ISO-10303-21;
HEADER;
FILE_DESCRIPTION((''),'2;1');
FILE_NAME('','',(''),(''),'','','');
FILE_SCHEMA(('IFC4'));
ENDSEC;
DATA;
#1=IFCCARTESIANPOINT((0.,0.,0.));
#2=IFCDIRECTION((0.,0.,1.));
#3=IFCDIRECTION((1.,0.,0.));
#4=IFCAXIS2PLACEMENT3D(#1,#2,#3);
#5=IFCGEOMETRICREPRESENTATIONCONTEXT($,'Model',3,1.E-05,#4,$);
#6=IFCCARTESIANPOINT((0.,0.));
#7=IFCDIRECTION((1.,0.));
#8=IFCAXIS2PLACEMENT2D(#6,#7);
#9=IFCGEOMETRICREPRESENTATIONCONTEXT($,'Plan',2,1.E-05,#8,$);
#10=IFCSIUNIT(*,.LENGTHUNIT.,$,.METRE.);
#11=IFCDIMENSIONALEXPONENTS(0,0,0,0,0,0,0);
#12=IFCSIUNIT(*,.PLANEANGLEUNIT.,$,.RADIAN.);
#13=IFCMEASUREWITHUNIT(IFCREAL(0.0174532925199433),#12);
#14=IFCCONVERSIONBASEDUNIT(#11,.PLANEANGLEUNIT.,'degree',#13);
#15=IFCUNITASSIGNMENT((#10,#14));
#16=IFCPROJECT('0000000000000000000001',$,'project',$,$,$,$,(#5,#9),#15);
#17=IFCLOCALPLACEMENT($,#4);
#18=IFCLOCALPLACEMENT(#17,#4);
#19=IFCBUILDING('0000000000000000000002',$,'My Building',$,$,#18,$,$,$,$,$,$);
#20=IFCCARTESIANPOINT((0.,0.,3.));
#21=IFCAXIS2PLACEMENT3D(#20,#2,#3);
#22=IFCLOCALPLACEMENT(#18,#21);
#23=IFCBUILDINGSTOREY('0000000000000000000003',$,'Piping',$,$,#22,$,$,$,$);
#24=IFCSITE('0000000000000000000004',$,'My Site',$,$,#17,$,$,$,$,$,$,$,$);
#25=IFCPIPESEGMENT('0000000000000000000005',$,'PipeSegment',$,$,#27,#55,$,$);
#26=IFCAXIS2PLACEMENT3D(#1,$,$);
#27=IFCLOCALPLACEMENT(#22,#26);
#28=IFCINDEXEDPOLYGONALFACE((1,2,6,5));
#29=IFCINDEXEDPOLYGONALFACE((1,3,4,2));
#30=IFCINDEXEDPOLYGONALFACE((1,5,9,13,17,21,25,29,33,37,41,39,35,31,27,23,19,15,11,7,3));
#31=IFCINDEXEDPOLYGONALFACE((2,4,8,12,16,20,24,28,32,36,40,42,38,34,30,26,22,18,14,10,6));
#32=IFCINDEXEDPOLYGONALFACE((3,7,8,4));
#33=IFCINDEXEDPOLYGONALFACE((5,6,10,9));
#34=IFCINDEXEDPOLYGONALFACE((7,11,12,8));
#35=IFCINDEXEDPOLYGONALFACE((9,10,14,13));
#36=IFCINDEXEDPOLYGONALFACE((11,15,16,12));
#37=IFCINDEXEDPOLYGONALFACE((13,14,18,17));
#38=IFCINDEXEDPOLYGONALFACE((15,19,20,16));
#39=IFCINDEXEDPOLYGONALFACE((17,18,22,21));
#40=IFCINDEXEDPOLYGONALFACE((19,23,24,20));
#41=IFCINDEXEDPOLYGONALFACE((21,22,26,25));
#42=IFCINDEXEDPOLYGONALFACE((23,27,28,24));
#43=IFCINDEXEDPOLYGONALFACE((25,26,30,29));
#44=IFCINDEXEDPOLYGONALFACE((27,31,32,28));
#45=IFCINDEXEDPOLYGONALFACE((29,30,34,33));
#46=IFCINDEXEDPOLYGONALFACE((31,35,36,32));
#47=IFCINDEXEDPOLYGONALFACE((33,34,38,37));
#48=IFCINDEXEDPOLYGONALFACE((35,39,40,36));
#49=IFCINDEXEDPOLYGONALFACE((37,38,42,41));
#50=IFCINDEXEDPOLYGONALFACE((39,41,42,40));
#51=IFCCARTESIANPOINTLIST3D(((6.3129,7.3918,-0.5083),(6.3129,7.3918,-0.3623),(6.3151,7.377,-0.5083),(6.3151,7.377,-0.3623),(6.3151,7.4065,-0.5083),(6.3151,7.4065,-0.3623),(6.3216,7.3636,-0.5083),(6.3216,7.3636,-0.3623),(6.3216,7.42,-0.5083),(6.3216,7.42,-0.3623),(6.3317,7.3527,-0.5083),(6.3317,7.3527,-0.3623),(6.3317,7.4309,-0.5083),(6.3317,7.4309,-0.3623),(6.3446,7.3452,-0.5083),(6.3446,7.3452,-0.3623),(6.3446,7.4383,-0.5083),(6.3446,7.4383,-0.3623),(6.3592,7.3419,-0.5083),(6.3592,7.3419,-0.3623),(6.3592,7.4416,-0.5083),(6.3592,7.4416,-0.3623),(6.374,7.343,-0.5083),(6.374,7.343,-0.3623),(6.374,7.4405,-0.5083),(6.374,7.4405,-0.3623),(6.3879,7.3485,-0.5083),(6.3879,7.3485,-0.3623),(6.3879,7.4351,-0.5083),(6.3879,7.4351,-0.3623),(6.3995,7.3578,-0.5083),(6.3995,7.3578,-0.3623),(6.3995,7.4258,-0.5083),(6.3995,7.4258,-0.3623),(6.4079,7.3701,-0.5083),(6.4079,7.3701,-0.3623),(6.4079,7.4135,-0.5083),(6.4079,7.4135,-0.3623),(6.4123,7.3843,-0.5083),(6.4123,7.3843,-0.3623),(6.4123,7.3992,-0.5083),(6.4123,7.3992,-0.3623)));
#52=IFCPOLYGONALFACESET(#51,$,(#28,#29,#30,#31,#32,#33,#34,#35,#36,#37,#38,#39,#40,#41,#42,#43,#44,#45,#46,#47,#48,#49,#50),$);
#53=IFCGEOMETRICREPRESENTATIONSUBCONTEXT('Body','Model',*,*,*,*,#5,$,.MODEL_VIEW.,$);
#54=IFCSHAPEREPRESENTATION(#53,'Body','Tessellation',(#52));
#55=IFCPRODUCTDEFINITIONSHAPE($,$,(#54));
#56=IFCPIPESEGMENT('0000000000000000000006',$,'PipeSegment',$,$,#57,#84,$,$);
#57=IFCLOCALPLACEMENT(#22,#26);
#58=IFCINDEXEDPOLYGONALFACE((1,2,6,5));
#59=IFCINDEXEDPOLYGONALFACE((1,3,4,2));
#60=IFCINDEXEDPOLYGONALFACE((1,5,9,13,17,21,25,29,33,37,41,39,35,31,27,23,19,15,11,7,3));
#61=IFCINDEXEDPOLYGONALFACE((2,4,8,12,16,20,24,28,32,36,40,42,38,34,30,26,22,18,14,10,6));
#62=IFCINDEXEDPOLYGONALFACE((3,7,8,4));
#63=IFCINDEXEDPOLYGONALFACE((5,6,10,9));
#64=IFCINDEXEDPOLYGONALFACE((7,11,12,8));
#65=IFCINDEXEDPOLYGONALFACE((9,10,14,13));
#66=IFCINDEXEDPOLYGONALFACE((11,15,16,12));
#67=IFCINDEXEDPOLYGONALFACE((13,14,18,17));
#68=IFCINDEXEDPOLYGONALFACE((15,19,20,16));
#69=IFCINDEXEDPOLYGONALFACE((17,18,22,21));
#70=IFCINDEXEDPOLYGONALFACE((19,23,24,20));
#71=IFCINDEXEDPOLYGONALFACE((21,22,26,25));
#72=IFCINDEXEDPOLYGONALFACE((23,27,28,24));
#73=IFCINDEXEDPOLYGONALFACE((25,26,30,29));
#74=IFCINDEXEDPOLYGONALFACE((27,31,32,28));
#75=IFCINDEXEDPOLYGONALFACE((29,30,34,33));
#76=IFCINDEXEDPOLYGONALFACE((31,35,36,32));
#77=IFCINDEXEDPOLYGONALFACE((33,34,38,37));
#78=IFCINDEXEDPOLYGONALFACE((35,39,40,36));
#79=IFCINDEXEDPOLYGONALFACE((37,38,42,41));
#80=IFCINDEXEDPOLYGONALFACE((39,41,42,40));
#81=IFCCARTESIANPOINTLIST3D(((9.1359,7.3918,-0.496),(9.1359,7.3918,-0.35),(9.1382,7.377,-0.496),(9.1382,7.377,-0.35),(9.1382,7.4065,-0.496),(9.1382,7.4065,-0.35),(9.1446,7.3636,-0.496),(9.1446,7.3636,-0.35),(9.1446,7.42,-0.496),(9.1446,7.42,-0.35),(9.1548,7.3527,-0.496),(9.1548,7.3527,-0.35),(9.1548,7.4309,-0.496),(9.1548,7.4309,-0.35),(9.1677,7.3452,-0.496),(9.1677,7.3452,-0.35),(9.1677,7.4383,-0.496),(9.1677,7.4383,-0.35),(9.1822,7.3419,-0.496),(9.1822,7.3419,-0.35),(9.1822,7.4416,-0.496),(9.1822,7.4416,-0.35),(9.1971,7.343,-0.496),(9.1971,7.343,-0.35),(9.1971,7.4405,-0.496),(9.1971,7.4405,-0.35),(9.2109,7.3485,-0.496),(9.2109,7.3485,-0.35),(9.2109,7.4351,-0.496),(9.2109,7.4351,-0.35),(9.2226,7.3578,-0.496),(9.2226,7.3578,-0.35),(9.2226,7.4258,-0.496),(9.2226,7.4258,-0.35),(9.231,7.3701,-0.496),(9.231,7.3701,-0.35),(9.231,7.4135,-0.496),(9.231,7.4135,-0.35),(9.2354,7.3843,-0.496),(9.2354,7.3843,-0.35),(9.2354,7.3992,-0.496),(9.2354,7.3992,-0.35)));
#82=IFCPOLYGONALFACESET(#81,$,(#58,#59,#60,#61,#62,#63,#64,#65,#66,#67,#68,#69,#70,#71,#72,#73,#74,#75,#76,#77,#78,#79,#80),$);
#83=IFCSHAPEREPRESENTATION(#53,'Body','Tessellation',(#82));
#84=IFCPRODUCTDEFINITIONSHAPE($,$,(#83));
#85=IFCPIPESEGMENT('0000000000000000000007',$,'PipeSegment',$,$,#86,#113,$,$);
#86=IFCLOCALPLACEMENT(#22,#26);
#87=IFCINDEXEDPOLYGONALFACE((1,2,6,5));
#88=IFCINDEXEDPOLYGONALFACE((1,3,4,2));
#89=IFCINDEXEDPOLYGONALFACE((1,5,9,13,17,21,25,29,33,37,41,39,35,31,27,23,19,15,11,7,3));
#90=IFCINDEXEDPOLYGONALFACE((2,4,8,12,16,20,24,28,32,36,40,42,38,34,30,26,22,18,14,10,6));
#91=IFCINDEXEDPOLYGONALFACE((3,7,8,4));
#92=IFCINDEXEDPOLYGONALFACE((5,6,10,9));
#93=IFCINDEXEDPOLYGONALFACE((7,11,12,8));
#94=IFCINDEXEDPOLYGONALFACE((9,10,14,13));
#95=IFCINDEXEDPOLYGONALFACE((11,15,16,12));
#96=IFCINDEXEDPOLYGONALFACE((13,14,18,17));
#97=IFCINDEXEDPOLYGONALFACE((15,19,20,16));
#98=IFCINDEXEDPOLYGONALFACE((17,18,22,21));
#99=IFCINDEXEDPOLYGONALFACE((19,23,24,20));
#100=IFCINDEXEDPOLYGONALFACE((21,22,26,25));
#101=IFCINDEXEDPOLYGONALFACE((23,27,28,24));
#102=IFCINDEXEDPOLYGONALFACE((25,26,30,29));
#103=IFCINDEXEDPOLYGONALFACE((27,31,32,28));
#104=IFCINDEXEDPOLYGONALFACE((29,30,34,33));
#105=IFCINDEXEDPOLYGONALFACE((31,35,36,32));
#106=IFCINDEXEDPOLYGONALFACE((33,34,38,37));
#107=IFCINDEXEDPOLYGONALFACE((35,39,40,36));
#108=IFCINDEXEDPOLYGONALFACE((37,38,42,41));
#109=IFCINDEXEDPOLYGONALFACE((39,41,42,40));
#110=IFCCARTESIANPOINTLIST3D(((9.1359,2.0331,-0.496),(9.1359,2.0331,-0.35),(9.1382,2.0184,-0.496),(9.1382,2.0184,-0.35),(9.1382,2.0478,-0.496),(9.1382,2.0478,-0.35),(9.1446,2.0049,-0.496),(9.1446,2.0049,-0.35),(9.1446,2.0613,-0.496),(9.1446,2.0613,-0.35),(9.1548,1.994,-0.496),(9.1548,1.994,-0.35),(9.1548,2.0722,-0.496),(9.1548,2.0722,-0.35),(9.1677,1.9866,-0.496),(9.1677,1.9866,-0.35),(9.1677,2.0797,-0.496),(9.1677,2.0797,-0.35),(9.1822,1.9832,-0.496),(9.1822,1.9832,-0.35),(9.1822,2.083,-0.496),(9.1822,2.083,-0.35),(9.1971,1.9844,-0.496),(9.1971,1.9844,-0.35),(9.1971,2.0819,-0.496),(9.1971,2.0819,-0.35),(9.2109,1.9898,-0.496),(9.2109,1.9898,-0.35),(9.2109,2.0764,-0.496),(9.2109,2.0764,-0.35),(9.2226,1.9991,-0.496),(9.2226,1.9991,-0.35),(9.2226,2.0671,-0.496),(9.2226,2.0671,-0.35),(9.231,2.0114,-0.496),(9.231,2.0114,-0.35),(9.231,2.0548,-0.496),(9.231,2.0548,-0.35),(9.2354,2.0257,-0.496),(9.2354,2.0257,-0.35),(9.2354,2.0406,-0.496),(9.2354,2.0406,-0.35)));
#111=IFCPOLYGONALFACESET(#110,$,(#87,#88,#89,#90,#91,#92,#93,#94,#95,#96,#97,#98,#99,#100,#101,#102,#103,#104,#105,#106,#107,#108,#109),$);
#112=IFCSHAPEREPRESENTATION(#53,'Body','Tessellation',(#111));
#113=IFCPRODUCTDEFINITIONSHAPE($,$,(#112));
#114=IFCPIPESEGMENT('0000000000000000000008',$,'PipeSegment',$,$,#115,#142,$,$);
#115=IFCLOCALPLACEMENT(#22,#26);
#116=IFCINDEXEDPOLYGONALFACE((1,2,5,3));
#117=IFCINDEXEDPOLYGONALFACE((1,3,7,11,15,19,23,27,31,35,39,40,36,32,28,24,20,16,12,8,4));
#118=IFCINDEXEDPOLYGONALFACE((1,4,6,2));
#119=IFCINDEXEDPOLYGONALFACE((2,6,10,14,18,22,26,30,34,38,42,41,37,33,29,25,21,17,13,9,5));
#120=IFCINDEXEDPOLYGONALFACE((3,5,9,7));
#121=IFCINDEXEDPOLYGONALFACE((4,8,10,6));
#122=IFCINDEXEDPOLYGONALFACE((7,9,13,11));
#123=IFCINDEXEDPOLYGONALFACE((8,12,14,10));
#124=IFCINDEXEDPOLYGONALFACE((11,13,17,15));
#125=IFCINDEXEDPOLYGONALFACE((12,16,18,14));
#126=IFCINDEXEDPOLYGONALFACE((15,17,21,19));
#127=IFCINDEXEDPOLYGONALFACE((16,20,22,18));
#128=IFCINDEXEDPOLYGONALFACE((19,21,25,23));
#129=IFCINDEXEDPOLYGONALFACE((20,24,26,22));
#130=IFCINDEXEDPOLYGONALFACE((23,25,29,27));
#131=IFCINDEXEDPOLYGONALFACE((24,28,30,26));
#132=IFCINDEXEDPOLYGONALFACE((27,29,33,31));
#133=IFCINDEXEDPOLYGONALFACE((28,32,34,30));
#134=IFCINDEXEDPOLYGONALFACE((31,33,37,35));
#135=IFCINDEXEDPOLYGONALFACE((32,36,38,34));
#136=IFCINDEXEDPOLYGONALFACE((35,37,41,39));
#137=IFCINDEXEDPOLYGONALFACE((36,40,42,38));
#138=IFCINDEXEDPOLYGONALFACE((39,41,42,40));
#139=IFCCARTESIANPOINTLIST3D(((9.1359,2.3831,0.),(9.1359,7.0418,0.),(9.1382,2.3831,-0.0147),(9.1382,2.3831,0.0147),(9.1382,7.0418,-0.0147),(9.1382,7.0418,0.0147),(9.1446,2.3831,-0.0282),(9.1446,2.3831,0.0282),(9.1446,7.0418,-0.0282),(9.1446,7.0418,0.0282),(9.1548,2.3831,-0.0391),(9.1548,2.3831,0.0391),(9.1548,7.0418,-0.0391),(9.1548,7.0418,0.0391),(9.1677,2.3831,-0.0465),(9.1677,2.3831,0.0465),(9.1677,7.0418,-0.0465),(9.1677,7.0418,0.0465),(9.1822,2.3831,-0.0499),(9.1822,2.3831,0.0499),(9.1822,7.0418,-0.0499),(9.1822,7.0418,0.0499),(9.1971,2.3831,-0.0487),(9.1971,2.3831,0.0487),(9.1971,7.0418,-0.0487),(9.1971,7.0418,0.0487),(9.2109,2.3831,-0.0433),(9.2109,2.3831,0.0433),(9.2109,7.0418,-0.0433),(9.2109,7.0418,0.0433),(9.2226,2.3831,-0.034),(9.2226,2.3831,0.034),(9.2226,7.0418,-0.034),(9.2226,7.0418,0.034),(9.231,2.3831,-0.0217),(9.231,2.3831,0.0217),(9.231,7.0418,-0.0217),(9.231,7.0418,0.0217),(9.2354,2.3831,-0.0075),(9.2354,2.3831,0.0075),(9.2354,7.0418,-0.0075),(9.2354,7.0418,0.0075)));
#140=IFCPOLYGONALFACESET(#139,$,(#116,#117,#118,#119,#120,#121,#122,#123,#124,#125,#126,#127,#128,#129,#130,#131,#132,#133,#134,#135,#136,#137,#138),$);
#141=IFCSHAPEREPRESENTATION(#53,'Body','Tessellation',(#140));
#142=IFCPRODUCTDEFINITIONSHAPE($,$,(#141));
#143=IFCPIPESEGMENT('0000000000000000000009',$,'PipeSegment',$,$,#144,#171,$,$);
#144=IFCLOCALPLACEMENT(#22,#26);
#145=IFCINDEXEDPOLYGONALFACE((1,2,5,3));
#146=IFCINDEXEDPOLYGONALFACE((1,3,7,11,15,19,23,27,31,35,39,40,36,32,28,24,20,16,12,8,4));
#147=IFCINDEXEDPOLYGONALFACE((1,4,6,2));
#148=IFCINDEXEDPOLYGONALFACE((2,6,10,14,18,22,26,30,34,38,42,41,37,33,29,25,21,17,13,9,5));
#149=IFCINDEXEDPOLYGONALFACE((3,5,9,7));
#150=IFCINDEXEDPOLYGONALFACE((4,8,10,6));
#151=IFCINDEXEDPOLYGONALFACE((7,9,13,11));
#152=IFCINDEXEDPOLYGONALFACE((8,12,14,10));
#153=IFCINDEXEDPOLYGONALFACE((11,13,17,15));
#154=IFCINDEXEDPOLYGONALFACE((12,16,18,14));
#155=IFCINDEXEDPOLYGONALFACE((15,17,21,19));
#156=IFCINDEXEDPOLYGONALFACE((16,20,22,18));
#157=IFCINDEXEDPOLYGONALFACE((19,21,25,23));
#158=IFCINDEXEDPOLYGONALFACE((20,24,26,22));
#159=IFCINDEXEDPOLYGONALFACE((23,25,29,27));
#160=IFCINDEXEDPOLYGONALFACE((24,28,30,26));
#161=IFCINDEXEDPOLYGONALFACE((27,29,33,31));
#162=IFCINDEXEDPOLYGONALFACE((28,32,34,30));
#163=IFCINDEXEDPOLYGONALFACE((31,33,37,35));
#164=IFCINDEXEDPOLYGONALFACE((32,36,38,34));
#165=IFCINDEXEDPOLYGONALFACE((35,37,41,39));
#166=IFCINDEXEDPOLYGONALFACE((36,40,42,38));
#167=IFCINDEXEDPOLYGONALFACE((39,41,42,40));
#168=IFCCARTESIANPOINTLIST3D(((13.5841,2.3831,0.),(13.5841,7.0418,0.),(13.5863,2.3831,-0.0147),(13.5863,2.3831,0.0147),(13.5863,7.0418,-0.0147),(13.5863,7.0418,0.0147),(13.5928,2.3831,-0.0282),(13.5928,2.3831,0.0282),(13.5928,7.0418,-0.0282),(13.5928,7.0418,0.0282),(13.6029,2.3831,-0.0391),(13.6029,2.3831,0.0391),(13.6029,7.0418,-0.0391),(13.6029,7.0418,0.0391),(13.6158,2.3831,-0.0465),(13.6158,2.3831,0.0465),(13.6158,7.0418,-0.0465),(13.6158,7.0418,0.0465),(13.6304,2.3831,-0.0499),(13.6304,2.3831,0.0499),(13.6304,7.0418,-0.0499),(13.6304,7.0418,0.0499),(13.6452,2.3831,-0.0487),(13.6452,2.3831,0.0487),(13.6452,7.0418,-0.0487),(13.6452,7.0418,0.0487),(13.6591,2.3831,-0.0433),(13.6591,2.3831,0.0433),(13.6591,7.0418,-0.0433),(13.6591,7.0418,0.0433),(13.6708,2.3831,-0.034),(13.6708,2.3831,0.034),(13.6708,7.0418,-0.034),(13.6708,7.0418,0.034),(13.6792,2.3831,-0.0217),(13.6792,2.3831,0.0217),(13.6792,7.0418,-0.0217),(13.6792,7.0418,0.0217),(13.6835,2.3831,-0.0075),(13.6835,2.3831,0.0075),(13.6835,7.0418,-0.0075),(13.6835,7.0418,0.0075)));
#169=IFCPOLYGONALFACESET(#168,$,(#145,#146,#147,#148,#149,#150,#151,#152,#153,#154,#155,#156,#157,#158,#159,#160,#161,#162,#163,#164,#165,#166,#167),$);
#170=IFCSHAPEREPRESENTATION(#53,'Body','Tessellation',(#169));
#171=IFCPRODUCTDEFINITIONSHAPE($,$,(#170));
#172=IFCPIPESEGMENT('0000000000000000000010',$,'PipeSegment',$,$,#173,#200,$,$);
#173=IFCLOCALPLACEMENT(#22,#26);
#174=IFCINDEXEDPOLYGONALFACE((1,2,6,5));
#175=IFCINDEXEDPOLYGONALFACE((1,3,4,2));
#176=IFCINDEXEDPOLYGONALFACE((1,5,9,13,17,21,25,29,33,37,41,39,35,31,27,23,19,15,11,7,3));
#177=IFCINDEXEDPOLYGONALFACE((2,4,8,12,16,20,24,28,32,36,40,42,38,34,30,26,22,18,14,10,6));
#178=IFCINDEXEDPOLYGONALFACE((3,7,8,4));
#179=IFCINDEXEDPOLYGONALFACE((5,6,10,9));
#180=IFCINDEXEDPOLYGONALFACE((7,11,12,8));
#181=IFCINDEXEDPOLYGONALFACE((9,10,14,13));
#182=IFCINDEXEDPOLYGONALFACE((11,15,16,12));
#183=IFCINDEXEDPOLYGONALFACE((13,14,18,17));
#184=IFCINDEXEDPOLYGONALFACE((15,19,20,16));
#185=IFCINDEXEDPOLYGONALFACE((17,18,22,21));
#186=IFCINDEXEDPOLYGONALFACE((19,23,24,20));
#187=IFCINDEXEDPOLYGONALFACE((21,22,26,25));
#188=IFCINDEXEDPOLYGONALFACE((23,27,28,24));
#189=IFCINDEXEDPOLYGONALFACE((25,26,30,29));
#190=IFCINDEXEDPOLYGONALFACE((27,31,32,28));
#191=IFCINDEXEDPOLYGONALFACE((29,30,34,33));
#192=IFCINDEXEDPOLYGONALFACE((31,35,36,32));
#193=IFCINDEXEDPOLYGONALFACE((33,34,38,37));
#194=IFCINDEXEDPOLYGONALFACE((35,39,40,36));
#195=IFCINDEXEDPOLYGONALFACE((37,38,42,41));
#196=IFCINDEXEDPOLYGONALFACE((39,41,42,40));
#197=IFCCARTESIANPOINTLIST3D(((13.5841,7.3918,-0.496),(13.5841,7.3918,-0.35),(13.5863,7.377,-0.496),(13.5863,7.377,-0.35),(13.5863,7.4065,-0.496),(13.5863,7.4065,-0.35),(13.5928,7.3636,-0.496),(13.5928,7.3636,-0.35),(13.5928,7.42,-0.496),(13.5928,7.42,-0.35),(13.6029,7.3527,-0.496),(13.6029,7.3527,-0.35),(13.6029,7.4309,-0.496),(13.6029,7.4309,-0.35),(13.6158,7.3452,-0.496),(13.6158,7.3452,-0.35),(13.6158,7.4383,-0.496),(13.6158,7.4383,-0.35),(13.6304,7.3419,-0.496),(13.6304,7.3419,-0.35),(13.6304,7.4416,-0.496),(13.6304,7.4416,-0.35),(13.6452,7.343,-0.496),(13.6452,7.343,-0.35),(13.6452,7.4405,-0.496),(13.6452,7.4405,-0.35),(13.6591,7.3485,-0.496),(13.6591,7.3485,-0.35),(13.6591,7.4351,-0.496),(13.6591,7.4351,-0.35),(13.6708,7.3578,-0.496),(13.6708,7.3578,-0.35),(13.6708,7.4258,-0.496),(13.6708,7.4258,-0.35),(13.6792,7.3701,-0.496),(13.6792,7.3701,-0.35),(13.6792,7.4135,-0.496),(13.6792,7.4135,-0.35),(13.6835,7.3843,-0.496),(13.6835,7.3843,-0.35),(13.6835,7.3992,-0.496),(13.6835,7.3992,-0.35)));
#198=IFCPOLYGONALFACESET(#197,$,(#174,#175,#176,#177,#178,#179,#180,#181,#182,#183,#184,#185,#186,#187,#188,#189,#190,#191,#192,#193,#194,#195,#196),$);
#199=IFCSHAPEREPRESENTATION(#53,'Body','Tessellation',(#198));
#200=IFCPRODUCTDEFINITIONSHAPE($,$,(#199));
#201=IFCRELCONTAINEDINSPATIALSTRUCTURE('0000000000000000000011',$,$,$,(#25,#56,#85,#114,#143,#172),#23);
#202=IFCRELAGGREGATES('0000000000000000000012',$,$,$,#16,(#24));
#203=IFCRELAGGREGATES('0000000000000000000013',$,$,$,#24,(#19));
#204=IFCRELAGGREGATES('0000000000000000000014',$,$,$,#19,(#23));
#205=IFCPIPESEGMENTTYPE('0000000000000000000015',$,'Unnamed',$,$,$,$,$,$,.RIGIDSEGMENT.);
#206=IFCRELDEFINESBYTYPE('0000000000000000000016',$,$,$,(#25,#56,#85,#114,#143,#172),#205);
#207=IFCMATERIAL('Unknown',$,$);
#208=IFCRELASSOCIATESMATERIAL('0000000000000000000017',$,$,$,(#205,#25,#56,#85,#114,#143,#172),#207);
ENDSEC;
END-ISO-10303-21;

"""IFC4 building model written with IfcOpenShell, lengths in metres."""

from ifc_helpers import new_model, entity, si_unit, converted_unit, frame, origin_with_axes, origin_2d_with_axis, place, context, subcontext, project, spatial, circle, extrude, material, material_profile, profile_set, profile_usage, type_object, element, save


model = new_model("IFC4")

# Units and contexts
model_context = context("Model", 3, precision=1e-05, world=origin_with_axes())
plan_context = context("Plan", 2, precision=1e-05, world=origin_2d_with_axis())
body_context = subcontext(model_context, "Body", "Model", "MODEL_VIEW")
ifc_project = project(units=[si_unit("LENGTHUNIT", "METRE"), converted_unit("PLANEANGLEUNIT", "degree", entity("IfcReal", 0.0174532925199433), si_unit("PLANEANGLEUNIT", "RADIAN"), dimensions=[0, 0, 0, 0, 0, 0, 0])], contexts=[model_context, plan_context])

# Site, building, storey
site_placement = place(None, origin_with_axes())
site = spatial("IfcSite", under=ifc_project, at=site_placement, Name="My Site")
building_placement = place(site_placement, origin_with_axes())
building = spatial("IfcBuilding", under=site, at=building_placement, Name="My Building")
storey_placement = place(building_placement, frame((0.0, 0.0, 3.0), z_axis=(0.0, 0.0, 1.0), x_axis=(1.0, 0.0, 0.0)))
storey = spatial("IfcBuildingStorey", under=building, at=storey_placement, Name="Piping")

# Pipe segments
ifc_material = material(Name="Unknown")
ifc_material_profile = material_profile(ifc_material, circle(Radius=0.05))
ifc_profile_set = profile_set([ifc_material_profile])
pipe_segment_type = type_object("IfcPipeSegmentType", Name="Unnamed", PredefinedType="RIGIDSEGMENT", material=ifc_profile_set)
ifc_profile_usage_1 = profile_usage(ifc_profile_set, cardinal=5)
pipe_segment_1_placement = place(storey_placement, frame((6.3629, 7.3918, -0.3623), z_axis=(0.0, 0.0, -1.0), x_axis=(-1.0, 0.0, 0.0)))
element("IfcPipeSegment", 1, at=pipe_segment_1_placement, inside=storey, type_object=pipe_segment_type, material=ifc_profile_usage_1, Name="PipeSegment", context=body_context, shape_type="SweptSolid", body=[
    extrude(circle(Radius=0.05), origin_with_axes(), (0.0, 0.0, 1.0), 0.1459),
])
ifc_profile_usage_2 = profile_usage(ifc_profile_set, cardinal=5)
pipe_segment_2_placement = place(storey_placement, frame((9.1859, 7.3918, -0.35), z_axis=(0.0, 0.0, -1.0), x_axis=(-1.0, 0.0, 0.0)))
element("IfcPipeSegment", 2, at=pipe_segment_2_placement, inside=storey, type_object=pipe_segment_type, material=ifc_profile_usage_2, Name="PipeSegment", context=body_context, shape_type="SweptSolid", body=[
    extrude(circle(Radius=0.05), origin_with_axes(), (0.0, 0.0, 1.0), 0.1459),
])
ifc_profile_usage_3 = profile_usage(ifc_profile_set, cardinal=5)
pipe_segment_3_placement = place(storey_placement, frame((9.1859, 2.0331, -0.35), z_axis=(0.0, 0.0, -1.0), x_axis=(-1.0, 0.0, 0.0)))
element("IfcPipeSegment", 3, at=pipe_segment_3_placement, inside=storey, type_object=pipe_segment_type, material=ifc_profile_usage_3, Name="PipeSegment", context=body_context, shape_type="SweptSolid", body=[
    extrude(circle(Radius=0.05), origin_with_axes(), (0.0, 0.0, 1.0), 0.1459),
])
ifc_profile_usage_4 = profile_usage(ifc_profile_set, cardinal=5)
pipe_segment_4_placement = place(storey_placement, frame((9.1859, 2.3831, 0.0), z_axis=(0.0, 1.0, 0.0), x_axis=(-1.0, 0.0, 0.0)))
element("IfcPipeSegment", 4, at=pipe_segment_4_placement, inside=storey, type_object=pipe_segment_type, material=ifc_profile_usage_4, Name="PipeSegment", context=body_context, shape_type="SweptSolid", body=[
    extrude(circle(Radius=0.05), origin_with_axes(), (0.0, 0.0, 1.0), 4.6587),
])
ifc_profile_usage_5 = profile_usage(ifc_profile_set, cardinal=5)
pipe_segment_5_placement = place(storey_placement, frame((13.6341, 2.3831, 0.0), z_axis=(0.0, 1.0, 0.0), x_axis=(-1.0, 0.0, 0.0)))
element("IfcPipeSegment", 5, at=pipe_segment_5_placement, inside=storey, type_object=pipe_segment_type, material=ifc_profile_usage_5, Name="PipeSegment", context=body_context, shape_type="SweptSolid", body=[
    extrude(circle(Radius=0.05), origin_with_axes(), (0.0, 0.0, 1.0), 4.6587),
])
ifc_profile_usage_6 = profile_usage(ifc_profile_set, cardinal=5)
pipe_segment_6_placement = place(storey_placement, frame((13.6341, 7.3918, -0.35), z_axis=(0.0, 0.0, -1.0), x_axis=(-1.0, 0.0, 0.0)))
element("IfcPipeSegment", 6, at=pipe_segment_6_placement, inside=storey, type_object=pipe_segment_type, material=ifc_profile_usage_6, Name="PipeSegment", context=body_context, shape_type="SweptSolid", body=[
    extrude(circle(Radius=0.05), origin_with_axes(), (0.0, 0.0, 1.0), 0.1459),
])

save(model, "model.ifc")
